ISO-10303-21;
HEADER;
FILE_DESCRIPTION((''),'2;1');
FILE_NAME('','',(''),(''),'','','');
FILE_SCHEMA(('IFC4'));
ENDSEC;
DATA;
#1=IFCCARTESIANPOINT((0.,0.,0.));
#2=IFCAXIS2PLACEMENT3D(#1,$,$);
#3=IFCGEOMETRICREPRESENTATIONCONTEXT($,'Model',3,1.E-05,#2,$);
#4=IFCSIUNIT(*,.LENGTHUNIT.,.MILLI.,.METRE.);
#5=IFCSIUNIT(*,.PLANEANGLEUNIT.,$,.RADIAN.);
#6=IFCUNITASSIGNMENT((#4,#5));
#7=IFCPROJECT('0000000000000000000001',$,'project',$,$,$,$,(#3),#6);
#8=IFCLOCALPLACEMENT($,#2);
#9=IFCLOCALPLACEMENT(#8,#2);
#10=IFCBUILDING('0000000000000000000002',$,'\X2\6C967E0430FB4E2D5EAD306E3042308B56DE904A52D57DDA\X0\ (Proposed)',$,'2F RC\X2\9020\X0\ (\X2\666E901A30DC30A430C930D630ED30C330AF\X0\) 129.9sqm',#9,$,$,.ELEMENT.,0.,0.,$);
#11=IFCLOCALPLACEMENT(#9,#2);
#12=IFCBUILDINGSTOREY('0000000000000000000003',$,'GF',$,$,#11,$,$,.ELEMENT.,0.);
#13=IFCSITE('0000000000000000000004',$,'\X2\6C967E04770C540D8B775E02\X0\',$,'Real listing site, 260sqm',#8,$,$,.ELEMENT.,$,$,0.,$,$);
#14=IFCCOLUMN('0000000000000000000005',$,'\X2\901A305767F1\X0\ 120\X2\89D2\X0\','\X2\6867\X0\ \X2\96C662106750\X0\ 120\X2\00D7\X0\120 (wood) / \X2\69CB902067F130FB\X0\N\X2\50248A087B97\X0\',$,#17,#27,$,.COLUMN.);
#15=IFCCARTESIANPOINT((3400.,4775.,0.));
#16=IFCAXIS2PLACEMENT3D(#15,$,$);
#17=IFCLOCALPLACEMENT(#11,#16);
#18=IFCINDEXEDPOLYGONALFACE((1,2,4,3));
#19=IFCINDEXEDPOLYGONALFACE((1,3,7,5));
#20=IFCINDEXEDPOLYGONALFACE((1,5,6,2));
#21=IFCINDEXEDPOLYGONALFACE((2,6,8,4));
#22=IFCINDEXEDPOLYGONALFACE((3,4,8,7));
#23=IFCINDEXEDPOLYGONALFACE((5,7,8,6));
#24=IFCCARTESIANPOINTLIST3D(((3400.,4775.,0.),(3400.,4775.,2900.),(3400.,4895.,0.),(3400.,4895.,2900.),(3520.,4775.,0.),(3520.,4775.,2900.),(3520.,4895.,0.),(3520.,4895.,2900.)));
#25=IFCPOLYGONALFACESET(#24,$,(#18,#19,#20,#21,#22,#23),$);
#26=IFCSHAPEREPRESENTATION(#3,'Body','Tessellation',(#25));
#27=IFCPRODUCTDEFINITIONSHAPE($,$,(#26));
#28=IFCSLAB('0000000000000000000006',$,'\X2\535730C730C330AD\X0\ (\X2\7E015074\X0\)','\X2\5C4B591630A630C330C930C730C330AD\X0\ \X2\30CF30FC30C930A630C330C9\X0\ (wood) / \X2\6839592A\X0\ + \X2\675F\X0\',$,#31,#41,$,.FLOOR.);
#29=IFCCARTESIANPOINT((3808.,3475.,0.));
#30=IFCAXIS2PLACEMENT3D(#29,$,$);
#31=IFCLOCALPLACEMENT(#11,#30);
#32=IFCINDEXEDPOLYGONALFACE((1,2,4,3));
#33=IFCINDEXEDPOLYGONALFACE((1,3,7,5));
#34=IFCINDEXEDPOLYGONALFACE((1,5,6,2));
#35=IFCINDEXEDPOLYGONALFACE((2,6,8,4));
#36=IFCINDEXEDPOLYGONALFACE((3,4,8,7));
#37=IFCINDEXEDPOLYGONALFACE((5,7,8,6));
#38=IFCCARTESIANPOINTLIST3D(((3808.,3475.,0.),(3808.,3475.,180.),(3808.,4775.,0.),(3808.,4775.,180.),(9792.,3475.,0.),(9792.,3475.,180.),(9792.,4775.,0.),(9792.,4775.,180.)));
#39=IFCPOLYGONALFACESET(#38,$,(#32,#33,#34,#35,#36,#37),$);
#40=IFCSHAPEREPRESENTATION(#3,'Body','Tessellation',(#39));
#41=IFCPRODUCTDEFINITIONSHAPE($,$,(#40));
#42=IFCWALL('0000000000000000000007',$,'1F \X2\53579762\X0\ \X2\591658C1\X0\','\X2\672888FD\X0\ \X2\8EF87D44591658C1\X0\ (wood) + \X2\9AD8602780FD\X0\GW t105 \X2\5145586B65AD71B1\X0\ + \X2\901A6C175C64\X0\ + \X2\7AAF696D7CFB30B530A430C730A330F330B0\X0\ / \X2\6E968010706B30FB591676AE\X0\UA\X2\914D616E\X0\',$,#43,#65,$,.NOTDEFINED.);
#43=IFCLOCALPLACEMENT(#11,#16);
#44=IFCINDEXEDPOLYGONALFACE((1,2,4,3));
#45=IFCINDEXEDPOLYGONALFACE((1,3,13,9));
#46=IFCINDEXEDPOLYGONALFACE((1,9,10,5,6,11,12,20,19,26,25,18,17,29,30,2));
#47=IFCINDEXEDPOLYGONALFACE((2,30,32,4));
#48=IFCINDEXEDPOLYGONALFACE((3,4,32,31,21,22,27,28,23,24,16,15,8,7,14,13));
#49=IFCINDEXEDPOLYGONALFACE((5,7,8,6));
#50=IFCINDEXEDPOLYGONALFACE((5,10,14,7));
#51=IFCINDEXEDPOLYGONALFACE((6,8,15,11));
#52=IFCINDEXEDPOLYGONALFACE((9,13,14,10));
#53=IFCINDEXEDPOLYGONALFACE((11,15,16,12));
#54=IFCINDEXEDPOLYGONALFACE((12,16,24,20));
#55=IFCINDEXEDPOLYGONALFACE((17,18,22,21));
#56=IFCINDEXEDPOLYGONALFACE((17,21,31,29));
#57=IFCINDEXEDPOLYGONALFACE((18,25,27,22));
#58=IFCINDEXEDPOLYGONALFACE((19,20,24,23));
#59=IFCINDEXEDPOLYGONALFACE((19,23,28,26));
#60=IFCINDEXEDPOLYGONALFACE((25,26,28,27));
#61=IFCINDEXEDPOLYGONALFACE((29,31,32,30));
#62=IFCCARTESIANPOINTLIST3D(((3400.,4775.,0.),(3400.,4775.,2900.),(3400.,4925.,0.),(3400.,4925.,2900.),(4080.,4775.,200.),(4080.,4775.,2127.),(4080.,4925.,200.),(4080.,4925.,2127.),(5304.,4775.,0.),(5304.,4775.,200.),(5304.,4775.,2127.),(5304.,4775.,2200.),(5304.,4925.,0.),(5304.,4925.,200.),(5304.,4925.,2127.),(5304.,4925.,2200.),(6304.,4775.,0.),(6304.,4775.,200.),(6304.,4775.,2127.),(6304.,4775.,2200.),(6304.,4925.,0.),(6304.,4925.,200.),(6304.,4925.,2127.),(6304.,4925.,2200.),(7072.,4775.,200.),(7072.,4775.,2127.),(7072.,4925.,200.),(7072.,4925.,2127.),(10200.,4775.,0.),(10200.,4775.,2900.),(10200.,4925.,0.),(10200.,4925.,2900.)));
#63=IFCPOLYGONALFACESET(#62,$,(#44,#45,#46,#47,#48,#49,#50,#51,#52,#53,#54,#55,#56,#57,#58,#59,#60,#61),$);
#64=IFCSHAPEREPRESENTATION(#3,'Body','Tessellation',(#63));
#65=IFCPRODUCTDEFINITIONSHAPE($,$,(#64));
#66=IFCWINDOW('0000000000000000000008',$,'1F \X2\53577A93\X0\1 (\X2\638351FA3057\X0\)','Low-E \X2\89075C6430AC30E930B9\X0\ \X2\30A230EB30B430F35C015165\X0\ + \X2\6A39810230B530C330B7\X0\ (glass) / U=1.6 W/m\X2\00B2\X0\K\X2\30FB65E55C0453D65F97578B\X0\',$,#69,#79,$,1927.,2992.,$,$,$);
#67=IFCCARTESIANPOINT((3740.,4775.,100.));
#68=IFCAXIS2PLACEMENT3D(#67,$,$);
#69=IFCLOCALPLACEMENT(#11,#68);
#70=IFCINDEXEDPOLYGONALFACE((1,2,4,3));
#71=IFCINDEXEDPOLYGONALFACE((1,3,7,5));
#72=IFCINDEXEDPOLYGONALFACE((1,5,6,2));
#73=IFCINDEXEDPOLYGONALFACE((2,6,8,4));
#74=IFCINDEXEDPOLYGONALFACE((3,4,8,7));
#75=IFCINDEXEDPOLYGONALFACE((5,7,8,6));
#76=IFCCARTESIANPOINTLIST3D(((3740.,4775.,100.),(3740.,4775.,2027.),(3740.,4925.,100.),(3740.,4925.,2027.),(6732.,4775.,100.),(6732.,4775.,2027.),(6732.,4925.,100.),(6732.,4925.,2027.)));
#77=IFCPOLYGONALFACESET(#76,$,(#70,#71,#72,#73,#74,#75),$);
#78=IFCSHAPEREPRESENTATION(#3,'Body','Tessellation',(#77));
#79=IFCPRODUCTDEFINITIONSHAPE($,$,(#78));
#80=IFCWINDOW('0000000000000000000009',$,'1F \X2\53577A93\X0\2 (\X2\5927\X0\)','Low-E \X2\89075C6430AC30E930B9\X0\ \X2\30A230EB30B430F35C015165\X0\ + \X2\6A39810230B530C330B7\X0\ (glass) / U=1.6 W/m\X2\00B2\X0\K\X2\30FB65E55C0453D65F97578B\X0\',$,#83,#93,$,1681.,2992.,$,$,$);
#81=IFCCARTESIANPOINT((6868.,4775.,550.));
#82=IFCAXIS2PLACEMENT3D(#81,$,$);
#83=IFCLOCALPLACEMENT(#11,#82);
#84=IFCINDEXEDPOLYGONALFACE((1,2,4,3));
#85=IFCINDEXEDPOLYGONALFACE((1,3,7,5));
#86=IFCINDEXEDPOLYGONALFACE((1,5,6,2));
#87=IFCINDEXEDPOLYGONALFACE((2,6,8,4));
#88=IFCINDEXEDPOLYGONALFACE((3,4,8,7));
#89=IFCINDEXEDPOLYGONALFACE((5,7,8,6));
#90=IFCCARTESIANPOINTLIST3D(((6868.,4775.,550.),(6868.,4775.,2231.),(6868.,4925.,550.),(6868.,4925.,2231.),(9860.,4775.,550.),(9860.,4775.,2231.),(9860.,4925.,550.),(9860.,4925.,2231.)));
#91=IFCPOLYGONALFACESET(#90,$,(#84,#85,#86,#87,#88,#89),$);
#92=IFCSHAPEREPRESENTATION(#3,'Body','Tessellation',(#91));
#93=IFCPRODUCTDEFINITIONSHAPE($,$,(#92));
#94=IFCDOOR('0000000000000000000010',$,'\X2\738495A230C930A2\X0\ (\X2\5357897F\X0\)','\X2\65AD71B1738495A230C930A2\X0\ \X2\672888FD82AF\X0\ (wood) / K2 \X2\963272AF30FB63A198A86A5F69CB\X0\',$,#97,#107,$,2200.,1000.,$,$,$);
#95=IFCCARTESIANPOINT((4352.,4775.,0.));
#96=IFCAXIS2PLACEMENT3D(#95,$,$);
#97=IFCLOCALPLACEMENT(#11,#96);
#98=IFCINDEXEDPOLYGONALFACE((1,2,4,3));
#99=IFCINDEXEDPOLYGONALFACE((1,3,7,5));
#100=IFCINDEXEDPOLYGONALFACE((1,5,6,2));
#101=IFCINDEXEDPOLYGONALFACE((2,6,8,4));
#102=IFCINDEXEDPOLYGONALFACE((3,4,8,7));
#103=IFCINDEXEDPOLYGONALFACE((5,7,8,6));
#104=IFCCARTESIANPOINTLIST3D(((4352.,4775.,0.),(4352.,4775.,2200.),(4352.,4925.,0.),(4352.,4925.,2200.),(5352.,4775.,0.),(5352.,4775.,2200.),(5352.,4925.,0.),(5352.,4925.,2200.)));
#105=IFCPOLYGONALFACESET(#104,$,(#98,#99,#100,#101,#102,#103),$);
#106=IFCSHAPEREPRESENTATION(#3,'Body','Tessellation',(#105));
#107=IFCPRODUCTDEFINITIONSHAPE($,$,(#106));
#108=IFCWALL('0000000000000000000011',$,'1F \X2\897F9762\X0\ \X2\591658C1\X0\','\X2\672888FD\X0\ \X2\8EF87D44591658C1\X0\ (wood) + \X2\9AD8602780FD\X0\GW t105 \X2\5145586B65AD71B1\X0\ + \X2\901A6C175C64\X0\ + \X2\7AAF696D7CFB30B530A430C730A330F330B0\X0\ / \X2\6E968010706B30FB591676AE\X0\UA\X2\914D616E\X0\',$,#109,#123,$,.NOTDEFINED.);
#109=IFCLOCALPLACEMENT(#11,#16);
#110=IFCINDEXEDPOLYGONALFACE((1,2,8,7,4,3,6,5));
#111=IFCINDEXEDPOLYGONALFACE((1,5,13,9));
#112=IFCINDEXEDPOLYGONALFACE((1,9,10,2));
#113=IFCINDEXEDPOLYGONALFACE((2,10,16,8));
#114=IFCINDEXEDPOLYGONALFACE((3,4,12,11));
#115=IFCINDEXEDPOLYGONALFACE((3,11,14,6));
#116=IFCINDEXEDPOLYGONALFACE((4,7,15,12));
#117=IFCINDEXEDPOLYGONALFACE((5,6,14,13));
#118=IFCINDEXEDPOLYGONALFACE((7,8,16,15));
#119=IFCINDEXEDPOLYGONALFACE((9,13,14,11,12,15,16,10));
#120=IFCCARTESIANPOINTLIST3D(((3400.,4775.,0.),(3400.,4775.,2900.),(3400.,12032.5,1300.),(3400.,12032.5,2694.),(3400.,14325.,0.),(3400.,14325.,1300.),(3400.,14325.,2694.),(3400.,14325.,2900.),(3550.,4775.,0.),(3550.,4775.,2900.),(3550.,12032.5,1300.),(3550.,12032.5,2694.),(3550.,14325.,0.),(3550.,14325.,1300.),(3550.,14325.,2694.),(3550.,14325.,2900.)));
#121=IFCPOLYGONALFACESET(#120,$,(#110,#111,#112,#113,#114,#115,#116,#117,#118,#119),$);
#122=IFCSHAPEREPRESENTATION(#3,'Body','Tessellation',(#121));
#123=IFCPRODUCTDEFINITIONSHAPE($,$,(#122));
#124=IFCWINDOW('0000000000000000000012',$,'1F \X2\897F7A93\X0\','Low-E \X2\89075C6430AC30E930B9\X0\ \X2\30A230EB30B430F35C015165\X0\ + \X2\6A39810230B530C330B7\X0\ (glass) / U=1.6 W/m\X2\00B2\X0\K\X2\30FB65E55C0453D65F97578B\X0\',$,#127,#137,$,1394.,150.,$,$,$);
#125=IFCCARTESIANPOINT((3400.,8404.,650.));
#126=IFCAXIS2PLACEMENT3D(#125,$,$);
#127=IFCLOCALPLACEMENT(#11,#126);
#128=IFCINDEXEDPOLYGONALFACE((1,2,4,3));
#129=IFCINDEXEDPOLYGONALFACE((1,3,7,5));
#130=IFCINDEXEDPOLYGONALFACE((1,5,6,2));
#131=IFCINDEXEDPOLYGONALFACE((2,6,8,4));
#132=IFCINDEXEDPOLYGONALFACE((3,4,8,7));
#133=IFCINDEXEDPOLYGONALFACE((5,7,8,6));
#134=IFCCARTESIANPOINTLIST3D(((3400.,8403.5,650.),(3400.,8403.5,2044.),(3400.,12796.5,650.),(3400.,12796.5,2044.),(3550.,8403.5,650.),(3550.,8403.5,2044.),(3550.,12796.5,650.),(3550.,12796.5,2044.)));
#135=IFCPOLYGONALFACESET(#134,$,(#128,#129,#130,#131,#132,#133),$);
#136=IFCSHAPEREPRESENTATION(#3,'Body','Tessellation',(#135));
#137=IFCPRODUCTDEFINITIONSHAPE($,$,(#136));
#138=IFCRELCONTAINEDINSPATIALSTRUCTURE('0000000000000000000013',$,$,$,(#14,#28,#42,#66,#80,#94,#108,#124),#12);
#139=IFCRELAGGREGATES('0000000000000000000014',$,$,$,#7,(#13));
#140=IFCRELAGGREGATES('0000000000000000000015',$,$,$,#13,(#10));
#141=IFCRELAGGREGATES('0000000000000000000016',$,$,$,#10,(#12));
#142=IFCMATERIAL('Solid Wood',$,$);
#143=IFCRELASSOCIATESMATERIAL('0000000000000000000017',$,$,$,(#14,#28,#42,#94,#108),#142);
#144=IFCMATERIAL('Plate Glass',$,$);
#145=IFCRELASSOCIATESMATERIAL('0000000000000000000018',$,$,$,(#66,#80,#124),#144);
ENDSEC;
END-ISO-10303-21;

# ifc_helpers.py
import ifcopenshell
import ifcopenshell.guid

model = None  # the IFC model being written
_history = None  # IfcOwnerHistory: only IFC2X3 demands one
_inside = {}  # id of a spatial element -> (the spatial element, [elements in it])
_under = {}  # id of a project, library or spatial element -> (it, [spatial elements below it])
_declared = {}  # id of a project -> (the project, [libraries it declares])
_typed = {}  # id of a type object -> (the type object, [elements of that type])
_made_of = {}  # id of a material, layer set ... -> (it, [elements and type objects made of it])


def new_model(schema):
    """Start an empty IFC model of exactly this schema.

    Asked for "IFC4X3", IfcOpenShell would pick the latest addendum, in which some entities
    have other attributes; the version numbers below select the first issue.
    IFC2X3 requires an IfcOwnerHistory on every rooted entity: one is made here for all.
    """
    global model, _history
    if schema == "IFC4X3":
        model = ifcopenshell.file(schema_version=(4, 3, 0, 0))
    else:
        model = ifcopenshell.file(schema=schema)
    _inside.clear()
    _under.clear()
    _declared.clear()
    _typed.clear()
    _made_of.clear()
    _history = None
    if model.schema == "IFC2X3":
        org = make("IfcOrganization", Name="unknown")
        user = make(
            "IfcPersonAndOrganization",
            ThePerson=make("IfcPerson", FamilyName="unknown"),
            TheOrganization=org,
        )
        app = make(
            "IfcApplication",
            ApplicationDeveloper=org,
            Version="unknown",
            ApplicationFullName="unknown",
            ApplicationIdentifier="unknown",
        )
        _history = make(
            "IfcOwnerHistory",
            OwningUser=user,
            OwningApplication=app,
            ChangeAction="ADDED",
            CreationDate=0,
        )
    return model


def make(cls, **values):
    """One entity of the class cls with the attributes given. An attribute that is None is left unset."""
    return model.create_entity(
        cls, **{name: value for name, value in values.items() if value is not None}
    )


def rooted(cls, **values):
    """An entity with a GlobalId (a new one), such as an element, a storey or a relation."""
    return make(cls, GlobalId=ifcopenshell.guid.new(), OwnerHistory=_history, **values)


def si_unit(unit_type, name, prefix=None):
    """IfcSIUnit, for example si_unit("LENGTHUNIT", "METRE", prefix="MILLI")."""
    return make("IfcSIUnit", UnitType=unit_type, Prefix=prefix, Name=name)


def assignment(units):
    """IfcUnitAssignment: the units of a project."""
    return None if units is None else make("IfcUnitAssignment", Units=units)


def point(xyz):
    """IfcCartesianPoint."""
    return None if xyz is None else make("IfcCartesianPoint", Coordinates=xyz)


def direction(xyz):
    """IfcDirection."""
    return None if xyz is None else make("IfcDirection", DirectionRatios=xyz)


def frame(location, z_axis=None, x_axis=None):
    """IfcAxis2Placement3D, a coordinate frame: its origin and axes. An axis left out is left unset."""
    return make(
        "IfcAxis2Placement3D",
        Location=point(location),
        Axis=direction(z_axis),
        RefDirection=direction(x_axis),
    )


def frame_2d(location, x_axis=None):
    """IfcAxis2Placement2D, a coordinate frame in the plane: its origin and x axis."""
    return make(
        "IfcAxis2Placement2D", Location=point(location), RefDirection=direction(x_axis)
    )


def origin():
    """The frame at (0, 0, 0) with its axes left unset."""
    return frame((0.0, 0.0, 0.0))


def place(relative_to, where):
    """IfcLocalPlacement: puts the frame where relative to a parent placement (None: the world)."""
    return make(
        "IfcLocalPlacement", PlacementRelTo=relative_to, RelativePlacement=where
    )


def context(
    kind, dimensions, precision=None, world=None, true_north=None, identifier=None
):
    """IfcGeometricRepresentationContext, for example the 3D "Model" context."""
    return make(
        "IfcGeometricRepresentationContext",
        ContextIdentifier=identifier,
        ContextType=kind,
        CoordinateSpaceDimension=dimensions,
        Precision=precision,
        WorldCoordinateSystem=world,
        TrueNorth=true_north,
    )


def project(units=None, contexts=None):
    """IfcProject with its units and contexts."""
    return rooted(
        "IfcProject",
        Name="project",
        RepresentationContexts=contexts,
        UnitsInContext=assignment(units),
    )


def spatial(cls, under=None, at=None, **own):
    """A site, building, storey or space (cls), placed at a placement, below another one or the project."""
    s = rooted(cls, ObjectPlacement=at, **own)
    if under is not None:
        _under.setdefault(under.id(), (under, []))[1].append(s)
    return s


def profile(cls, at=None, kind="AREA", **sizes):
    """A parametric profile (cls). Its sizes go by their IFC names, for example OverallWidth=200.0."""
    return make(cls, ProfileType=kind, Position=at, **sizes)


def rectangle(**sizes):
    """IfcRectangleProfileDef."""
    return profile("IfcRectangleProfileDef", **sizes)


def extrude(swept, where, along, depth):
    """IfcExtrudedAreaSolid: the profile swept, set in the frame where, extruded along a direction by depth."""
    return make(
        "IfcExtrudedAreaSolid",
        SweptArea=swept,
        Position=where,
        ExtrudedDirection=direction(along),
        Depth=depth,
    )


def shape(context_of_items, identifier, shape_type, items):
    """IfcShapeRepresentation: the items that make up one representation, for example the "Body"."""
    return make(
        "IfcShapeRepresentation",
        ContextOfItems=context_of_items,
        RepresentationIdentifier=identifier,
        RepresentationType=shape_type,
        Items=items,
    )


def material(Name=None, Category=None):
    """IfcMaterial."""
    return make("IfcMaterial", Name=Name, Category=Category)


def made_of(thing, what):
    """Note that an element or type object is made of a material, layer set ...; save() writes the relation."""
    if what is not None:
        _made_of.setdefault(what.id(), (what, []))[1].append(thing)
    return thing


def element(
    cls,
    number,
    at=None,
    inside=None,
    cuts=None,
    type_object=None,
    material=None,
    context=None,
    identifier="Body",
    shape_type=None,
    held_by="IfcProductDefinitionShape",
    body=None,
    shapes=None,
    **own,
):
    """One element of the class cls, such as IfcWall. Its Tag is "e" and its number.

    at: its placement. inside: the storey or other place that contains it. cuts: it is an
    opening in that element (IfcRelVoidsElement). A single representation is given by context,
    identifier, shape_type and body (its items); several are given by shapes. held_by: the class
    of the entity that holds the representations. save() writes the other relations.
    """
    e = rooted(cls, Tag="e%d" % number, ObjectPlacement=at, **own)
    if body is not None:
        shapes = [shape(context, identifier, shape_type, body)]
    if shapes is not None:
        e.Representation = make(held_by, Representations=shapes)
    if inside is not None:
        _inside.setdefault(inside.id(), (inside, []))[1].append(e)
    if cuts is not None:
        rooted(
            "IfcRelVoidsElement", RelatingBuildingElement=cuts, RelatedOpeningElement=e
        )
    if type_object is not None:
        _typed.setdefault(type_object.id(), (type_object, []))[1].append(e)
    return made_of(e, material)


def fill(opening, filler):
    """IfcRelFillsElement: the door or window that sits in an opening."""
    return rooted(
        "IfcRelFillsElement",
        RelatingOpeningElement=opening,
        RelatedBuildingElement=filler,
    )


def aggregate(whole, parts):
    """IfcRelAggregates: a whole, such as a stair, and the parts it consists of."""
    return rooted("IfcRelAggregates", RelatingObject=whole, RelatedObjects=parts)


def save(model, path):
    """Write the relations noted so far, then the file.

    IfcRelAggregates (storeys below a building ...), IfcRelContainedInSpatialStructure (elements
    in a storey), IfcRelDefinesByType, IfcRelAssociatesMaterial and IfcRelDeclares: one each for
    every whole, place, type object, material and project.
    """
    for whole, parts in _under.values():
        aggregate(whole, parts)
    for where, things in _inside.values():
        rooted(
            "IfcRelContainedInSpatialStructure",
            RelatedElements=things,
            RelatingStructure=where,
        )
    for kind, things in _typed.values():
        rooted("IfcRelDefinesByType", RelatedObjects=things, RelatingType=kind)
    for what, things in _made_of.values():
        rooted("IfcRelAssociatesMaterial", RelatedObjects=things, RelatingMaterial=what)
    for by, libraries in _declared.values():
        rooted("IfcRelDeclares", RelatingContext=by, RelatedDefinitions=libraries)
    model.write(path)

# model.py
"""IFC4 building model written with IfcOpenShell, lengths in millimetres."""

from ifc_helpers import new_model, si_unit, frame, frame_2d, origin, place, context, project, spatial, rectangle, extrude, material, element, fill, save


model = new_model("IFC4")

# Units and contexts
model_context = context("Model", 3, precision=1e-05, world=origin())
ifc_project = project(units=[si_unit("LENGTHUNIT", "METRE", prefix="MILLI"), si_unit("PLANEANGLEUNIT", "RADIAN")], contexts=[model_context])

# Site, building, storey
site_placement = place(None, origin())
site = spatial("IfcSite", under=ifc_project, at=site_placement, Name="沖縄県名護市", ObjectType="Real listing site, 260sqm", CompositionType="ELEMENT", RefElevation=0.0)
building_placement = place(site_placement, origin())
building = spatial("IfcBuilding", under=site, at=building_placement, Name="沖縄・中庭のある回遊動線 (Proposed)", ObjectType="2F RC造 (普通ボイドブロック) 129.9sqm", CompositionType="ELEMENT", ElevationOfRefHeight=0.0, ElevationOfTerrain=0.0)
storey_placement = place(building_placement, origin())
storey = spatial("IfcBuildingStorey", under=building, at=storey_placement, Name="GF", CompositionType="ELEMENT", Elevation=0.0)

# Column
ifc_material_1 = material(Name="Solid Wood")
column_placement = place(storey_placement, frame((3400.0, 4775.0, 0.0)))
element("IfcColumn", 1, at=column_placement, inside=storey, material=ifc_material_1, Name="通し柱 120角", Description="桧 集成材 120×120 (wood) / 構造柱・N値計算", PredefinedType="COLUMN", context=model_context, shape_type="SweptSolid", body=[
    extrude(rectangle(XDim=120.0, YDim=120.0, at=frame_2d((60.0, 60.0))), frame((3400.0, 4775.0, 0.0)), (0.0, 0.0, 1.0), 2900.0),
])

# Slab
slab_1_placement = place(storey_placement, frame((3808.0, 3475.0, 0.0)))
element("IfcSlab", 2, at=slab_1_placement, inside=storey, material=ifc_material_1, Name="南デッキ (縁側)", Description="屋外ウッドデッキ ハードウッド (wood) / 根太 + 束", PredefinedType="FLOOR", context=model_context, shape_type="SweptSolid", body=[
    extrude(rectangle(XDim=5984.0, YDim=1300.0, at=frame_2d((2992.0, 650.0))), frame((3808.0, 3475.0, 0.0)), (0.0, 0.0, 1.0), 180.0),
])

# Wall, openings, windows, door
wall_1_placement = place(storey_placement, frame((3400.0, 4775.0, 0.0)))
wall_1 = element("IfcWall", 3, at=wall_1_placement, inside=storey, material=ifc_material_1, Name="1F 南面 外壁", Description="木製 軸組外壁 (wood) + 高性能GW t105 充填断熱 + 通気層 + 窯業系サイディング / 準耐火・外皮UA配慮", PredefinedType="NOTDEFINED", context=model_context, shape_type="SweptSolid", body=[
    extrude(rectangle(XDim=6800.0, YDim=150.0, at=frame_2d((3400.0, 75.0))), frame((3400.0, 4775.0, 0.0)), (0.0, 0.0, 1.0), 2900.0),
])
opening_1_placement = place(storey_placement, frame((3740.0, 4775.0, 100.0)))
opening_1 = element("IfcOpeningElement", 4, at=opening_1_placement, cuts=wall_1, PredefinedType="NOTDEFINED", context=model_context, shape_type="SweptSolid", body=[
    extrude(rectangle(XDim=2992.0, YDim=150.0, at=frame_2d((1496.0, 75.0))), frame((3740.0, 4775.0, 100.0)), (0.0, 0.0, 1.0), 1927.0),
])
opening_2_placement = place(storey_placement, frame((6868.0, 4775.0, 550.0)))
opening_2 = element("IfcOpeningElement", 5, at=opening_2_placement, cuts=wall_1, PredefinedType="NOTDEFINED", context=model_context, shape_type="SweptSolid", body=[
    extrude(rectangle(XDim=2992.0, YDim=150.0, at=frame_2d((1496.0, 75.0))), frame((6868.0, 4775.0, 550.0)), (0.0, 0.0, 1.0), 1681.0),
])
opening_3_placement = place(storey_placement, frame((4352.0, 4775.0, 0.0)))
opening_3 = element("IfcOpeningElement", 6, at=opening_3_placement, cuts=wall_1, PredefinedType="NOTDEFINED", context=model_context, shape_type="SweptSolid", body=[
    extrude(rectangle(XDim=1000.0, YDim=150.0, at=frame_2d((500.0, 75.0))), frame((4352.0, 4775.0, 0.0)), (0.0, 0.0, 1.0), 2200.0),
])
ifc_material_2 = material(Name="Plate Glass")
window_1_placement = place(storey_placement, frame((3740.0, 4775.0, 100.0)))
window_1 = element("IfcWindow", 7, at=window_1_placement, inside=storey, material=ifc_material_2, Name="1F 南窓1 (掃出し)", Description="Low-E 複層ガラス アルゴン封入 + 樹脂サッシ (glass) / U=1.6 W/m²K・日射取得型", OverallHeight=1927.0, OverallWidth=2992.0, context=model_context, shape_type="SweptSolid", body=[
    extrude(rectangle(XDim=2992.0, YDim=150.0, at=frame_2d((1496.0, 75.0))), frame((3740.0, 4775.0, 100.0)), (0.0, 0.0, 1.0), 1927.0),
])
fill(opening_1, window_1)
window_2_placement = place(storey_placement, frame((6868.0, 4775.0, 550.0)))
window_2 = element("IfcWindow", 8, at=window_2_placement, inside=storey, material=ifc_material_2, Name="1F 南窓2 (大)", Description="Low-E 複層ガラス アルゴン封入 + 樹脂サッシ (glass) / U=1.6 W/m²K・日射取得型", OverallHeight=1681.0, OverallWidth=2992.0, context=model_context, shape_type="SweptSolid", body=[
    extrude(rectangle(XDim=2992.0, YDim=150.0, at=frame_2d((1496.0, 75.0))), frame((6868.0, 4775.0, 550.0)), (0.0, 0.0, 1.0), 1681.0),
])
fill(opening_2, window_2)
door_placement = place(storey_placement, frame((4352.0, 4775.0, 0.0)))
door = element("IfcDoor", 9, at=door_placement, inside=storey, material=ifc_material_1, Name="玄関ドア (南西)", Description="断熱玄関ドア 木製芯 (wood) / K2 防犯・採風機構", OverallHeight=2200.0, OverallWidth=1000.0, context=model_context, shape_type="SweptSolid", body=[
    extrude(rectangle(XDim=1000.0, YDim=150.0, at=frame_2d((500.0, 75.0))), frame((4352.0, 4775.0, 0.0)), (0.0, 0.0, 1.0), 2200.0),
])
fill(opening_3, door)

# Wall, opening, window
wall_2_placement = place(storey_placement, frame((3400.0, 4775.0, 0.0)))
wall_2 = element("IfcWall", 10, at=wall_2_placement, inside=storey, material=ifc_material_1, Name="1F 西面 外壁", Description="木製 軸組外壁 (wood) + 高性能GW t105 充填断熱 + 通気層 + 窯業系サイディング / 準耐火・外皮UA配慮", PredefinedType="NOTDEFINED", context=model_context, shape_type="SweptSolid", body=[
    extrude(rectangle(XDim=150.0, YDim=9550.0, at=frame_2d((75.0, 4775.0))), frame((3400.0, 4775.0, 0.0)), (0.0, 0.0, 1.0), 2900.0),
])
opening_4_placement = place(storey_placement, frame((3400.0, 8404.0, 650.0)))
opening_4 = element("IfcOpeningElement", 11, at=opening_4_placement, cuts=wall_2, PredefinedType="NOTDEFINED", context=model_context, shape_type="SweptSolid", body=[
    extrude(rectangle(XDim=150.0, YDim=4393.0, at=frame_2d((75.0, 2196.0))), frame((3400.0, 8404.0, 650.0)), (0.0, 0.0, 1.0), 1394.0),
])
window_3_placement = place(storey_placement, frame((3400.0, 8404.0, 650.0)))
window_3 = element("IfcWindow", 12, at=window_3_placement, inside=storey, material=ifc_material_2, Name="1F 西窓", Description="Low-E 複層ガラス アルゴン封入 + 樹脂サッシ (glass) / U=1.6 W/m²K・日射取得型", OverallHeight=1394.0, OverallWidth=150.0, context=model_context, shape_type="SweptSolid", body=[
    extrude(rectangle(XDim=150.0, YDim=4393.0, at=frame_2d((75.0, 2196.0))), frame((3400.0, 8404.0, 650.0)), (0.0, 0.0, 1.0), 1394.0),
])
fill(opening_4, window_3)

save(model, "model.ifc")
